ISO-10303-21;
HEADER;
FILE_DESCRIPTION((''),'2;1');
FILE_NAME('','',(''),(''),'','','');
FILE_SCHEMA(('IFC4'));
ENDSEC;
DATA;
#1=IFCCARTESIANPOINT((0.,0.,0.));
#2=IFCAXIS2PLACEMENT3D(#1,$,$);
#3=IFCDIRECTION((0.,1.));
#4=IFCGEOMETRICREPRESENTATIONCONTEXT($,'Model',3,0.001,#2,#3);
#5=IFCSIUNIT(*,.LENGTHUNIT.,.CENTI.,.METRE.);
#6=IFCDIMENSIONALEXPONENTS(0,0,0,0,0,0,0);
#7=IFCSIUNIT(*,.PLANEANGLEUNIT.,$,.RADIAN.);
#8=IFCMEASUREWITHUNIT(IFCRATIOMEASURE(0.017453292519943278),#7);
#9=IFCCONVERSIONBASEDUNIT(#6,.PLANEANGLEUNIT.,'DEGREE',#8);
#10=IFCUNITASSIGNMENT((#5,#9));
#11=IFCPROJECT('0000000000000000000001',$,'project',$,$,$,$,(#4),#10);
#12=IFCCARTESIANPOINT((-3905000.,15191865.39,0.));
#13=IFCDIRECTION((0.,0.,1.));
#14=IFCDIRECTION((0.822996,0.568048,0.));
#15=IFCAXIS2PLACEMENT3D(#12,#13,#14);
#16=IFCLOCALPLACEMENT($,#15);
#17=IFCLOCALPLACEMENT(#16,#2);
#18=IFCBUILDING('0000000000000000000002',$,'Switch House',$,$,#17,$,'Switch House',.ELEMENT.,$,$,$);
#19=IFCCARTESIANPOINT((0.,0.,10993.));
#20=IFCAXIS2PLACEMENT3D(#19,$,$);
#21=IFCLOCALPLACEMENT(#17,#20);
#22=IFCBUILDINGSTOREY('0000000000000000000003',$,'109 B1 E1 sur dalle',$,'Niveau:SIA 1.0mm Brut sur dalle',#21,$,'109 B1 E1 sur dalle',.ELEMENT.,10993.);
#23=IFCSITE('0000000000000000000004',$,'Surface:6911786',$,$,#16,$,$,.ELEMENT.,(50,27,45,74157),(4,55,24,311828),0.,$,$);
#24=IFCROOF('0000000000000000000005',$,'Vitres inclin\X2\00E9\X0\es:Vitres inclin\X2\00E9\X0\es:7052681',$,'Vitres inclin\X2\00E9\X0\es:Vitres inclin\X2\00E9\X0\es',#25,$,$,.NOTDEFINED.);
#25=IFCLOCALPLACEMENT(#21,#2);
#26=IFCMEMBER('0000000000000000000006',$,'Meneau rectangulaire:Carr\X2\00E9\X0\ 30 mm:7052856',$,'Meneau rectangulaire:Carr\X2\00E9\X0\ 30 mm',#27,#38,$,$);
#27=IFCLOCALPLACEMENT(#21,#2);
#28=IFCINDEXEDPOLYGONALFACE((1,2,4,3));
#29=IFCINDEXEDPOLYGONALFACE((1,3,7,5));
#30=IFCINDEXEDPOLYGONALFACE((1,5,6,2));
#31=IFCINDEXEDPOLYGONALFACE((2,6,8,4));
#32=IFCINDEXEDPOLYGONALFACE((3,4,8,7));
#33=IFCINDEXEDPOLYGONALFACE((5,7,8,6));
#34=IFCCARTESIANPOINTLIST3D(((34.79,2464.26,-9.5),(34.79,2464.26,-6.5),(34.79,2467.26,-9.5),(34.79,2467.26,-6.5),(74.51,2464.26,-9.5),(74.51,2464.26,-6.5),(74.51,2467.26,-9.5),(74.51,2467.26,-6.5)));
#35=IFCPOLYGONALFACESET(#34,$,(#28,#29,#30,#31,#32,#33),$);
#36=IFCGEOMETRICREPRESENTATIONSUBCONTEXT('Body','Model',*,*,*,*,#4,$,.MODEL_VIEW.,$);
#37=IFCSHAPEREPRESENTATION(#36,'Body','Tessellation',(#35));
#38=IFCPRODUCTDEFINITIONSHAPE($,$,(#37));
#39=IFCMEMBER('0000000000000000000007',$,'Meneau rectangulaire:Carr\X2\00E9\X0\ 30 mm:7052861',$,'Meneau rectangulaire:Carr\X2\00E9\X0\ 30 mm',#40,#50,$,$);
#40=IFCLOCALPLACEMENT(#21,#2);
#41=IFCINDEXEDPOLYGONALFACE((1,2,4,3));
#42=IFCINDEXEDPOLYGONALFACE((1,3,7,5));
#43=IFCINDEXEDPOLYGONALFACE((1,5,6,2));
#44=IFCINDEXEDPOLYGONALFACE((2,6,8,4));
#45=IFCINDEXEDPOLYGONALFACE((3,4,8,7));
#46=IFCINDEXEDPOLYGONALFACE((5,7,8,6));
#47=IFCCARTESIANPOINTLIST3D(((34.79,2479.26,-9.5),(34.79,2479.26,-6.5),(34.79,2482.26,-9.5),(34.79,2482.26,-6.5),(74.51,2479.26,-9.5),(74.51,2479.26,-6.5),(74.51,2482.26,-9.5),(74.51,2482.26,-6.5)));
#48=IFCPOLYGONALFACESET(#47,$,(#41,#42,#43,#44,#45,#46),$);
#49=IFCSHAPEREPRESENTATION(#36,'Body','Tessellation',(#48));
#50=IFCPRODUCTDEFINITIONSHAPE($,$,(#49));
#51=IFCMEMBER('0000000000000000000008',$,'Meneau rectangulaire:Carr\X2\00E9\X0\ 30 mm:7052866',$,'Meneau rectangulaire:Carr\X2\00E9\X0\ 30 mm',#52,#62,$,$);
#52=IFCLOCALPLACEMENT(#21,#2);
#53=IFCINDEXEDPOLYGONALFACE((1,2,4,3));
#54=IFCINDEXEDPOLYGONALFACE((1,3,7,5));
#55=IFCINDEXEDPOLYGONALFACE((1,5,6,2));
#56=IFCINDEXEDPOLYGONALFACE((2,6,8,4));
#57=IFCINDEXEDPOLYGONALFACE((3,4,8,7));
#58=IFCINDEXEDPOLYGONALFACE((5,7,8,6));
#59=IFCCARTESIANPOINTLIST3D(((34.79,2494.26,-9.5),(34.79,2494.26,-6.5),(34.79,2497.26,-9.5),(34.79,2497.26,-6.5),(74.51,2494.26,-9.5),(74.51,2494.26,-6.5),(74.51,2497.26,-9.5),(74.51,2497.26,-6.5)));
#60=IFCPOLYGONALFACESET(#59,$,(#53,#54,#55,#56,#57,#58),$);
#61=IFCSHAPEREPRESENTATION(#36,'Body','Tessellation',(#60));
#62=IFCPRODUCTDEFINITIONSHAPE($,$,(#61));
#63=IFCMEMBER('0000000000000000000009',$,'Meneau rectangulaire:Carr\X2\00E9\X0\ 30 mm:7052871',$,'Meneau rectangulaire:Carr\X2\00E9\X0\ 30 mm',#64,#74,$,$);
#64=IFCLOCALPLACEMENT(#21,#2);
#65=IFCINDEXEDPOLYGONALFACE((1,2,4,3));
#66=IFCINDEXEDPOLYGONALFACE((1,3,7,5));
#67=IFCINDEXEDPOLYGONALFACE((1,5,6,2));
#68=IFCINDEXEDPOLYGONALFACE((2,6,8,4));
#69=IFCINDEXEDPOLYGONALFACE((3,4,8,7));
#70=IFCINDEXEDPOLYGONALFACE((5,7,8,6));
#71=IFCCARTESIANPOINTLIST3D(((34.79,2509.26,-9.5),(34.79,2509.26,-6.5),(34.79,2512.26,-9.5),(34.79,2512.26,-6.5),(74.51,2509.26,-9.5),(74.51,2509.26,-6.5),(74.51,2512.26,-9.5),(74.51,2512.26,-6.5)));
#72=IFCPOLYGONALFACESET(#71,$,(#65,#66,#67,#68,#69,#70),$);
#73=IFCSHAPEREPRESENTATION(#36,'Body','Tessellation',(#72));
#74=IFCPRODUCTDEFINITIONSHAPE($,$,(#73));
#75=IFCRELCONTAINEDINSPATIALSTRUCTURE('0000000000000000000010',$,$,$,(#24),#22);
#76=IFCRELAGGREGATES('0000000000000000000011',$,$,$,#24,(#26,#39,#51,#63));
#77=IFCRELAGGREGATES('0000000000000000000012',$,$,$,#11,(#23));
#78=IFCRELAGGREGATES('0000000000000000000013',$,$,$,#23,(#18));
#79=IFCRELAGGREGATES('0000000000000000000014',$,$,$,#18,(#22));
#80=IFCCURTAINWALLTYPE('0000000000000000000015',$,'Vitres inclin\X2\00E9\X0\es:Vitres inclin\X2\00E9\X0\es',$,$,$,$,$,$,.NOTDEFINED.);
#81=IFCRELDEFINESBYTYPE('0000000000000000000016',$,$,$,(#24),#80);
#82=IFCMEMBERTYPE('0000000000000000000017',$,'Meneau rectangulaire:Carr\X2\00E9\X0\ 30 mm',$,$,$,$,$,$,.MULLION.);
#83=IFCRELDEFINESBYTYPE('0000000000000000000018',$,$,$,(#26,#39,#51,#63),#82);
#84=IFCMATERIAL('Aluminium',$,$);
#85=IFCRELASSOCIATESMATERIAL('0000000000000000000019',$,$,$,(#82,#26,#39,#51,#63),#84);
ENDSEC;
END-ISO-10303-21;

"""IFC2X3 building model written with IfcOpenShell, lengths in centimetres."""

from ifc_helpers import new_model, entity, si_unit, converted_unit, direction, frame, origin, origin_2d_with_axis, place, context, subcontext, project, spatial, rectangle, extrude, source, transform, mapped, material, type_object, type_shapes, element, aggregate, save


model = new_model("IFC2X3")

# Units and contexts
model_context = context("Model", 3, precision=0.001, world=origin(), true_north=direction((0.0, 1.0)))
body_context = subcontext(model_context, "Body", "Model", "MODEL_VIEW")
ifc_project = project(units=[si_unit("LENGTHUNIT", "METRE", prefix="CENTI"), converted_unit("PLANEANGLEUNIT", "DEGREE", entity("IfcRatioMeasure", 0.017453292519943278), si_unit("PLANEANGLEUNIT", "RADIAN"), dimensions=[0, 0, 0, 0, 0, 0, 0])], contexts=[model_context])

# Site, building, storey
site_placement = place(None, frame((-3905000.0, 15191865.39, 0.0), z_axis=(0.0, 0.0, 1.0), x_axis=(0.822996, 0.568048, 0.0)))
site = spatial("IfcSite", under=ifc_project, at=site_placement, Name="Surface:6911786", CompositionType="ELEMENT", RefLatitude=(50, 27, 45, 74157), RefLongitude=(4, 55, 24, 311828), RefElevation=0.0)
building_placement = place(site_placement, origin())
building = spatial("IfcBuilding", under=site, at=building_placement, Name="Switch House", LongName="Switch House", CompositionType="ELEMENT")
storey_placement = place(building_placement, frame((0.0, 0.0, 10993.0)))
storey = spatial("IfcBuildingStorey", under=building, at=storey_placement, Name="109 B1 E1 sur dalle", ObjectType="Niveau:SIA 1.0mm Brut sur dalle", LongName="109 B1 E1 sur dalle", CompositionType="ELEMENT", Elevation=10993.0)

# Roof, members
curtain_wall_type = type_object("IfcCurtainWallType", Name="Vitres inclinées:Vitres inclinées", PredefinedType="NOTDEFINED")
ifc_material = material(Name="Aluminium")
roof_1_placement = place(storey_placement, frame((0.0, 0.0, -10993.0)))
roof_1 = element("IfcRoof", 1, at=roof_1_placement, inside=storey, type_object=curtain_wall_type, Name="Vitres inclinées:Vitres inclinées:7052681", ObjectType="Vitres inclinées:Vitres inclinées", ShapeType="NOTDEFINED")
member_type_1 = type_object("IfcMemberType", Name="Meneau rectangulaire:Carré 30 mm", PredefinedType="MULLION", material=ifc_material)
shared_shape_1 = source(origin(), body_context, "Body", "SweptSolid", [
    extrude(rectangle(XDim=3.0, YDim=3.0, at=origin_2d_with_axis()), frame((0.0, 0.0, -39.72), z_axis=(0.0, 0.0, 1.0), x_axis=(0.0, -1.0, 0.0)), (0.0, 0.0, 1.0), 39.72),
])
type_shapes(member_type_1, [shared_shape_1])
member_1_placement = place(roof_1_placement, frame((34.79, 2465.76, 10985.0), z_axis=(-1.0, 0.0, 0.0), x_axis=(0.0, 1.0, 0.0)))
member_1 = element("IfcMember", 2, at=member_1_placement, type_object=member_type_1, material=ifc_material, Name="Meneau rectangulaire:Carré 30 mm:7052856", ObjectType="Meneau rectangulaire:Carré 30 mm", context=body_context, shape_type="MappedRepresentation", body=[
    mapped(shared_shape_1, transform((0.0, 0.0, 0.0), scale=1.0)),
])
member_2_placement = place(roof_1_placement, frame((34.79, 2480.76, 10985.0), z_axis=(-1.0, 0.0, 0.0), x_axis=(0.0, 1.0, 0.0)))
member_2 = element("IfcMember", 3, at=member_2_placement, type_object=member_type_1, material=ifc_material, Name="Meneau rectangulaire:Carré 30 mm:7052861", ObjectType="Meneau rectangulaire:Carré 30 mm", context=body_context, shape_type="MappedRepresentation", body=[
    mapped(shared_shape_1, transform((0.0, 0.0, 0.0), scale=1.0)),
])
member_3_placement = place(roof_1_placement, frame((34.79, 2495.76, 10985.0), z_axis=(-1.0, 0.0, 0.0), x_axis=(0.0, 1.0, 0.0)))
member_3 = element("IfcMember", 4, at=member_3_placement, type_object=member_type_1, material=ifc_material, Name="Meneau rectangulaire:Carré 30 mm:7052866", ObjectType="Meneau rectangulaire:Carré 30 mm", context=body_context, shape_type="MappedRepresentation", body=[
    mapped(shared_shape_1, transform((0.0, 0.0, 0.0), scale=1.0)),
])
member_4_placement = place(roof_1_placement, frame((34.79, 2510.76, 10985.0), z_axis=(-1.0, 0.0, 0.0), x_axis=(0.0, 1.0, 0.0)))
member_4 = element("IfcMember", 5, at=member_4_placement, type_object=member_type_1, material=ifc_material, Name="Meneau rectangulaire:Carré 30 mm:7052871", ObjectType="Meneau rectangulaire:Carré 30 mm", context=body_context, shape_type="MappedRepresentation", body=[
    mapped(shared_shape_1, transform((0.0, 0.0, 0.0), scale=1.0)),
])
aggregate(roof_1, [member_1, member_2, member_3, member_4])

save(model, "model.ifc")
